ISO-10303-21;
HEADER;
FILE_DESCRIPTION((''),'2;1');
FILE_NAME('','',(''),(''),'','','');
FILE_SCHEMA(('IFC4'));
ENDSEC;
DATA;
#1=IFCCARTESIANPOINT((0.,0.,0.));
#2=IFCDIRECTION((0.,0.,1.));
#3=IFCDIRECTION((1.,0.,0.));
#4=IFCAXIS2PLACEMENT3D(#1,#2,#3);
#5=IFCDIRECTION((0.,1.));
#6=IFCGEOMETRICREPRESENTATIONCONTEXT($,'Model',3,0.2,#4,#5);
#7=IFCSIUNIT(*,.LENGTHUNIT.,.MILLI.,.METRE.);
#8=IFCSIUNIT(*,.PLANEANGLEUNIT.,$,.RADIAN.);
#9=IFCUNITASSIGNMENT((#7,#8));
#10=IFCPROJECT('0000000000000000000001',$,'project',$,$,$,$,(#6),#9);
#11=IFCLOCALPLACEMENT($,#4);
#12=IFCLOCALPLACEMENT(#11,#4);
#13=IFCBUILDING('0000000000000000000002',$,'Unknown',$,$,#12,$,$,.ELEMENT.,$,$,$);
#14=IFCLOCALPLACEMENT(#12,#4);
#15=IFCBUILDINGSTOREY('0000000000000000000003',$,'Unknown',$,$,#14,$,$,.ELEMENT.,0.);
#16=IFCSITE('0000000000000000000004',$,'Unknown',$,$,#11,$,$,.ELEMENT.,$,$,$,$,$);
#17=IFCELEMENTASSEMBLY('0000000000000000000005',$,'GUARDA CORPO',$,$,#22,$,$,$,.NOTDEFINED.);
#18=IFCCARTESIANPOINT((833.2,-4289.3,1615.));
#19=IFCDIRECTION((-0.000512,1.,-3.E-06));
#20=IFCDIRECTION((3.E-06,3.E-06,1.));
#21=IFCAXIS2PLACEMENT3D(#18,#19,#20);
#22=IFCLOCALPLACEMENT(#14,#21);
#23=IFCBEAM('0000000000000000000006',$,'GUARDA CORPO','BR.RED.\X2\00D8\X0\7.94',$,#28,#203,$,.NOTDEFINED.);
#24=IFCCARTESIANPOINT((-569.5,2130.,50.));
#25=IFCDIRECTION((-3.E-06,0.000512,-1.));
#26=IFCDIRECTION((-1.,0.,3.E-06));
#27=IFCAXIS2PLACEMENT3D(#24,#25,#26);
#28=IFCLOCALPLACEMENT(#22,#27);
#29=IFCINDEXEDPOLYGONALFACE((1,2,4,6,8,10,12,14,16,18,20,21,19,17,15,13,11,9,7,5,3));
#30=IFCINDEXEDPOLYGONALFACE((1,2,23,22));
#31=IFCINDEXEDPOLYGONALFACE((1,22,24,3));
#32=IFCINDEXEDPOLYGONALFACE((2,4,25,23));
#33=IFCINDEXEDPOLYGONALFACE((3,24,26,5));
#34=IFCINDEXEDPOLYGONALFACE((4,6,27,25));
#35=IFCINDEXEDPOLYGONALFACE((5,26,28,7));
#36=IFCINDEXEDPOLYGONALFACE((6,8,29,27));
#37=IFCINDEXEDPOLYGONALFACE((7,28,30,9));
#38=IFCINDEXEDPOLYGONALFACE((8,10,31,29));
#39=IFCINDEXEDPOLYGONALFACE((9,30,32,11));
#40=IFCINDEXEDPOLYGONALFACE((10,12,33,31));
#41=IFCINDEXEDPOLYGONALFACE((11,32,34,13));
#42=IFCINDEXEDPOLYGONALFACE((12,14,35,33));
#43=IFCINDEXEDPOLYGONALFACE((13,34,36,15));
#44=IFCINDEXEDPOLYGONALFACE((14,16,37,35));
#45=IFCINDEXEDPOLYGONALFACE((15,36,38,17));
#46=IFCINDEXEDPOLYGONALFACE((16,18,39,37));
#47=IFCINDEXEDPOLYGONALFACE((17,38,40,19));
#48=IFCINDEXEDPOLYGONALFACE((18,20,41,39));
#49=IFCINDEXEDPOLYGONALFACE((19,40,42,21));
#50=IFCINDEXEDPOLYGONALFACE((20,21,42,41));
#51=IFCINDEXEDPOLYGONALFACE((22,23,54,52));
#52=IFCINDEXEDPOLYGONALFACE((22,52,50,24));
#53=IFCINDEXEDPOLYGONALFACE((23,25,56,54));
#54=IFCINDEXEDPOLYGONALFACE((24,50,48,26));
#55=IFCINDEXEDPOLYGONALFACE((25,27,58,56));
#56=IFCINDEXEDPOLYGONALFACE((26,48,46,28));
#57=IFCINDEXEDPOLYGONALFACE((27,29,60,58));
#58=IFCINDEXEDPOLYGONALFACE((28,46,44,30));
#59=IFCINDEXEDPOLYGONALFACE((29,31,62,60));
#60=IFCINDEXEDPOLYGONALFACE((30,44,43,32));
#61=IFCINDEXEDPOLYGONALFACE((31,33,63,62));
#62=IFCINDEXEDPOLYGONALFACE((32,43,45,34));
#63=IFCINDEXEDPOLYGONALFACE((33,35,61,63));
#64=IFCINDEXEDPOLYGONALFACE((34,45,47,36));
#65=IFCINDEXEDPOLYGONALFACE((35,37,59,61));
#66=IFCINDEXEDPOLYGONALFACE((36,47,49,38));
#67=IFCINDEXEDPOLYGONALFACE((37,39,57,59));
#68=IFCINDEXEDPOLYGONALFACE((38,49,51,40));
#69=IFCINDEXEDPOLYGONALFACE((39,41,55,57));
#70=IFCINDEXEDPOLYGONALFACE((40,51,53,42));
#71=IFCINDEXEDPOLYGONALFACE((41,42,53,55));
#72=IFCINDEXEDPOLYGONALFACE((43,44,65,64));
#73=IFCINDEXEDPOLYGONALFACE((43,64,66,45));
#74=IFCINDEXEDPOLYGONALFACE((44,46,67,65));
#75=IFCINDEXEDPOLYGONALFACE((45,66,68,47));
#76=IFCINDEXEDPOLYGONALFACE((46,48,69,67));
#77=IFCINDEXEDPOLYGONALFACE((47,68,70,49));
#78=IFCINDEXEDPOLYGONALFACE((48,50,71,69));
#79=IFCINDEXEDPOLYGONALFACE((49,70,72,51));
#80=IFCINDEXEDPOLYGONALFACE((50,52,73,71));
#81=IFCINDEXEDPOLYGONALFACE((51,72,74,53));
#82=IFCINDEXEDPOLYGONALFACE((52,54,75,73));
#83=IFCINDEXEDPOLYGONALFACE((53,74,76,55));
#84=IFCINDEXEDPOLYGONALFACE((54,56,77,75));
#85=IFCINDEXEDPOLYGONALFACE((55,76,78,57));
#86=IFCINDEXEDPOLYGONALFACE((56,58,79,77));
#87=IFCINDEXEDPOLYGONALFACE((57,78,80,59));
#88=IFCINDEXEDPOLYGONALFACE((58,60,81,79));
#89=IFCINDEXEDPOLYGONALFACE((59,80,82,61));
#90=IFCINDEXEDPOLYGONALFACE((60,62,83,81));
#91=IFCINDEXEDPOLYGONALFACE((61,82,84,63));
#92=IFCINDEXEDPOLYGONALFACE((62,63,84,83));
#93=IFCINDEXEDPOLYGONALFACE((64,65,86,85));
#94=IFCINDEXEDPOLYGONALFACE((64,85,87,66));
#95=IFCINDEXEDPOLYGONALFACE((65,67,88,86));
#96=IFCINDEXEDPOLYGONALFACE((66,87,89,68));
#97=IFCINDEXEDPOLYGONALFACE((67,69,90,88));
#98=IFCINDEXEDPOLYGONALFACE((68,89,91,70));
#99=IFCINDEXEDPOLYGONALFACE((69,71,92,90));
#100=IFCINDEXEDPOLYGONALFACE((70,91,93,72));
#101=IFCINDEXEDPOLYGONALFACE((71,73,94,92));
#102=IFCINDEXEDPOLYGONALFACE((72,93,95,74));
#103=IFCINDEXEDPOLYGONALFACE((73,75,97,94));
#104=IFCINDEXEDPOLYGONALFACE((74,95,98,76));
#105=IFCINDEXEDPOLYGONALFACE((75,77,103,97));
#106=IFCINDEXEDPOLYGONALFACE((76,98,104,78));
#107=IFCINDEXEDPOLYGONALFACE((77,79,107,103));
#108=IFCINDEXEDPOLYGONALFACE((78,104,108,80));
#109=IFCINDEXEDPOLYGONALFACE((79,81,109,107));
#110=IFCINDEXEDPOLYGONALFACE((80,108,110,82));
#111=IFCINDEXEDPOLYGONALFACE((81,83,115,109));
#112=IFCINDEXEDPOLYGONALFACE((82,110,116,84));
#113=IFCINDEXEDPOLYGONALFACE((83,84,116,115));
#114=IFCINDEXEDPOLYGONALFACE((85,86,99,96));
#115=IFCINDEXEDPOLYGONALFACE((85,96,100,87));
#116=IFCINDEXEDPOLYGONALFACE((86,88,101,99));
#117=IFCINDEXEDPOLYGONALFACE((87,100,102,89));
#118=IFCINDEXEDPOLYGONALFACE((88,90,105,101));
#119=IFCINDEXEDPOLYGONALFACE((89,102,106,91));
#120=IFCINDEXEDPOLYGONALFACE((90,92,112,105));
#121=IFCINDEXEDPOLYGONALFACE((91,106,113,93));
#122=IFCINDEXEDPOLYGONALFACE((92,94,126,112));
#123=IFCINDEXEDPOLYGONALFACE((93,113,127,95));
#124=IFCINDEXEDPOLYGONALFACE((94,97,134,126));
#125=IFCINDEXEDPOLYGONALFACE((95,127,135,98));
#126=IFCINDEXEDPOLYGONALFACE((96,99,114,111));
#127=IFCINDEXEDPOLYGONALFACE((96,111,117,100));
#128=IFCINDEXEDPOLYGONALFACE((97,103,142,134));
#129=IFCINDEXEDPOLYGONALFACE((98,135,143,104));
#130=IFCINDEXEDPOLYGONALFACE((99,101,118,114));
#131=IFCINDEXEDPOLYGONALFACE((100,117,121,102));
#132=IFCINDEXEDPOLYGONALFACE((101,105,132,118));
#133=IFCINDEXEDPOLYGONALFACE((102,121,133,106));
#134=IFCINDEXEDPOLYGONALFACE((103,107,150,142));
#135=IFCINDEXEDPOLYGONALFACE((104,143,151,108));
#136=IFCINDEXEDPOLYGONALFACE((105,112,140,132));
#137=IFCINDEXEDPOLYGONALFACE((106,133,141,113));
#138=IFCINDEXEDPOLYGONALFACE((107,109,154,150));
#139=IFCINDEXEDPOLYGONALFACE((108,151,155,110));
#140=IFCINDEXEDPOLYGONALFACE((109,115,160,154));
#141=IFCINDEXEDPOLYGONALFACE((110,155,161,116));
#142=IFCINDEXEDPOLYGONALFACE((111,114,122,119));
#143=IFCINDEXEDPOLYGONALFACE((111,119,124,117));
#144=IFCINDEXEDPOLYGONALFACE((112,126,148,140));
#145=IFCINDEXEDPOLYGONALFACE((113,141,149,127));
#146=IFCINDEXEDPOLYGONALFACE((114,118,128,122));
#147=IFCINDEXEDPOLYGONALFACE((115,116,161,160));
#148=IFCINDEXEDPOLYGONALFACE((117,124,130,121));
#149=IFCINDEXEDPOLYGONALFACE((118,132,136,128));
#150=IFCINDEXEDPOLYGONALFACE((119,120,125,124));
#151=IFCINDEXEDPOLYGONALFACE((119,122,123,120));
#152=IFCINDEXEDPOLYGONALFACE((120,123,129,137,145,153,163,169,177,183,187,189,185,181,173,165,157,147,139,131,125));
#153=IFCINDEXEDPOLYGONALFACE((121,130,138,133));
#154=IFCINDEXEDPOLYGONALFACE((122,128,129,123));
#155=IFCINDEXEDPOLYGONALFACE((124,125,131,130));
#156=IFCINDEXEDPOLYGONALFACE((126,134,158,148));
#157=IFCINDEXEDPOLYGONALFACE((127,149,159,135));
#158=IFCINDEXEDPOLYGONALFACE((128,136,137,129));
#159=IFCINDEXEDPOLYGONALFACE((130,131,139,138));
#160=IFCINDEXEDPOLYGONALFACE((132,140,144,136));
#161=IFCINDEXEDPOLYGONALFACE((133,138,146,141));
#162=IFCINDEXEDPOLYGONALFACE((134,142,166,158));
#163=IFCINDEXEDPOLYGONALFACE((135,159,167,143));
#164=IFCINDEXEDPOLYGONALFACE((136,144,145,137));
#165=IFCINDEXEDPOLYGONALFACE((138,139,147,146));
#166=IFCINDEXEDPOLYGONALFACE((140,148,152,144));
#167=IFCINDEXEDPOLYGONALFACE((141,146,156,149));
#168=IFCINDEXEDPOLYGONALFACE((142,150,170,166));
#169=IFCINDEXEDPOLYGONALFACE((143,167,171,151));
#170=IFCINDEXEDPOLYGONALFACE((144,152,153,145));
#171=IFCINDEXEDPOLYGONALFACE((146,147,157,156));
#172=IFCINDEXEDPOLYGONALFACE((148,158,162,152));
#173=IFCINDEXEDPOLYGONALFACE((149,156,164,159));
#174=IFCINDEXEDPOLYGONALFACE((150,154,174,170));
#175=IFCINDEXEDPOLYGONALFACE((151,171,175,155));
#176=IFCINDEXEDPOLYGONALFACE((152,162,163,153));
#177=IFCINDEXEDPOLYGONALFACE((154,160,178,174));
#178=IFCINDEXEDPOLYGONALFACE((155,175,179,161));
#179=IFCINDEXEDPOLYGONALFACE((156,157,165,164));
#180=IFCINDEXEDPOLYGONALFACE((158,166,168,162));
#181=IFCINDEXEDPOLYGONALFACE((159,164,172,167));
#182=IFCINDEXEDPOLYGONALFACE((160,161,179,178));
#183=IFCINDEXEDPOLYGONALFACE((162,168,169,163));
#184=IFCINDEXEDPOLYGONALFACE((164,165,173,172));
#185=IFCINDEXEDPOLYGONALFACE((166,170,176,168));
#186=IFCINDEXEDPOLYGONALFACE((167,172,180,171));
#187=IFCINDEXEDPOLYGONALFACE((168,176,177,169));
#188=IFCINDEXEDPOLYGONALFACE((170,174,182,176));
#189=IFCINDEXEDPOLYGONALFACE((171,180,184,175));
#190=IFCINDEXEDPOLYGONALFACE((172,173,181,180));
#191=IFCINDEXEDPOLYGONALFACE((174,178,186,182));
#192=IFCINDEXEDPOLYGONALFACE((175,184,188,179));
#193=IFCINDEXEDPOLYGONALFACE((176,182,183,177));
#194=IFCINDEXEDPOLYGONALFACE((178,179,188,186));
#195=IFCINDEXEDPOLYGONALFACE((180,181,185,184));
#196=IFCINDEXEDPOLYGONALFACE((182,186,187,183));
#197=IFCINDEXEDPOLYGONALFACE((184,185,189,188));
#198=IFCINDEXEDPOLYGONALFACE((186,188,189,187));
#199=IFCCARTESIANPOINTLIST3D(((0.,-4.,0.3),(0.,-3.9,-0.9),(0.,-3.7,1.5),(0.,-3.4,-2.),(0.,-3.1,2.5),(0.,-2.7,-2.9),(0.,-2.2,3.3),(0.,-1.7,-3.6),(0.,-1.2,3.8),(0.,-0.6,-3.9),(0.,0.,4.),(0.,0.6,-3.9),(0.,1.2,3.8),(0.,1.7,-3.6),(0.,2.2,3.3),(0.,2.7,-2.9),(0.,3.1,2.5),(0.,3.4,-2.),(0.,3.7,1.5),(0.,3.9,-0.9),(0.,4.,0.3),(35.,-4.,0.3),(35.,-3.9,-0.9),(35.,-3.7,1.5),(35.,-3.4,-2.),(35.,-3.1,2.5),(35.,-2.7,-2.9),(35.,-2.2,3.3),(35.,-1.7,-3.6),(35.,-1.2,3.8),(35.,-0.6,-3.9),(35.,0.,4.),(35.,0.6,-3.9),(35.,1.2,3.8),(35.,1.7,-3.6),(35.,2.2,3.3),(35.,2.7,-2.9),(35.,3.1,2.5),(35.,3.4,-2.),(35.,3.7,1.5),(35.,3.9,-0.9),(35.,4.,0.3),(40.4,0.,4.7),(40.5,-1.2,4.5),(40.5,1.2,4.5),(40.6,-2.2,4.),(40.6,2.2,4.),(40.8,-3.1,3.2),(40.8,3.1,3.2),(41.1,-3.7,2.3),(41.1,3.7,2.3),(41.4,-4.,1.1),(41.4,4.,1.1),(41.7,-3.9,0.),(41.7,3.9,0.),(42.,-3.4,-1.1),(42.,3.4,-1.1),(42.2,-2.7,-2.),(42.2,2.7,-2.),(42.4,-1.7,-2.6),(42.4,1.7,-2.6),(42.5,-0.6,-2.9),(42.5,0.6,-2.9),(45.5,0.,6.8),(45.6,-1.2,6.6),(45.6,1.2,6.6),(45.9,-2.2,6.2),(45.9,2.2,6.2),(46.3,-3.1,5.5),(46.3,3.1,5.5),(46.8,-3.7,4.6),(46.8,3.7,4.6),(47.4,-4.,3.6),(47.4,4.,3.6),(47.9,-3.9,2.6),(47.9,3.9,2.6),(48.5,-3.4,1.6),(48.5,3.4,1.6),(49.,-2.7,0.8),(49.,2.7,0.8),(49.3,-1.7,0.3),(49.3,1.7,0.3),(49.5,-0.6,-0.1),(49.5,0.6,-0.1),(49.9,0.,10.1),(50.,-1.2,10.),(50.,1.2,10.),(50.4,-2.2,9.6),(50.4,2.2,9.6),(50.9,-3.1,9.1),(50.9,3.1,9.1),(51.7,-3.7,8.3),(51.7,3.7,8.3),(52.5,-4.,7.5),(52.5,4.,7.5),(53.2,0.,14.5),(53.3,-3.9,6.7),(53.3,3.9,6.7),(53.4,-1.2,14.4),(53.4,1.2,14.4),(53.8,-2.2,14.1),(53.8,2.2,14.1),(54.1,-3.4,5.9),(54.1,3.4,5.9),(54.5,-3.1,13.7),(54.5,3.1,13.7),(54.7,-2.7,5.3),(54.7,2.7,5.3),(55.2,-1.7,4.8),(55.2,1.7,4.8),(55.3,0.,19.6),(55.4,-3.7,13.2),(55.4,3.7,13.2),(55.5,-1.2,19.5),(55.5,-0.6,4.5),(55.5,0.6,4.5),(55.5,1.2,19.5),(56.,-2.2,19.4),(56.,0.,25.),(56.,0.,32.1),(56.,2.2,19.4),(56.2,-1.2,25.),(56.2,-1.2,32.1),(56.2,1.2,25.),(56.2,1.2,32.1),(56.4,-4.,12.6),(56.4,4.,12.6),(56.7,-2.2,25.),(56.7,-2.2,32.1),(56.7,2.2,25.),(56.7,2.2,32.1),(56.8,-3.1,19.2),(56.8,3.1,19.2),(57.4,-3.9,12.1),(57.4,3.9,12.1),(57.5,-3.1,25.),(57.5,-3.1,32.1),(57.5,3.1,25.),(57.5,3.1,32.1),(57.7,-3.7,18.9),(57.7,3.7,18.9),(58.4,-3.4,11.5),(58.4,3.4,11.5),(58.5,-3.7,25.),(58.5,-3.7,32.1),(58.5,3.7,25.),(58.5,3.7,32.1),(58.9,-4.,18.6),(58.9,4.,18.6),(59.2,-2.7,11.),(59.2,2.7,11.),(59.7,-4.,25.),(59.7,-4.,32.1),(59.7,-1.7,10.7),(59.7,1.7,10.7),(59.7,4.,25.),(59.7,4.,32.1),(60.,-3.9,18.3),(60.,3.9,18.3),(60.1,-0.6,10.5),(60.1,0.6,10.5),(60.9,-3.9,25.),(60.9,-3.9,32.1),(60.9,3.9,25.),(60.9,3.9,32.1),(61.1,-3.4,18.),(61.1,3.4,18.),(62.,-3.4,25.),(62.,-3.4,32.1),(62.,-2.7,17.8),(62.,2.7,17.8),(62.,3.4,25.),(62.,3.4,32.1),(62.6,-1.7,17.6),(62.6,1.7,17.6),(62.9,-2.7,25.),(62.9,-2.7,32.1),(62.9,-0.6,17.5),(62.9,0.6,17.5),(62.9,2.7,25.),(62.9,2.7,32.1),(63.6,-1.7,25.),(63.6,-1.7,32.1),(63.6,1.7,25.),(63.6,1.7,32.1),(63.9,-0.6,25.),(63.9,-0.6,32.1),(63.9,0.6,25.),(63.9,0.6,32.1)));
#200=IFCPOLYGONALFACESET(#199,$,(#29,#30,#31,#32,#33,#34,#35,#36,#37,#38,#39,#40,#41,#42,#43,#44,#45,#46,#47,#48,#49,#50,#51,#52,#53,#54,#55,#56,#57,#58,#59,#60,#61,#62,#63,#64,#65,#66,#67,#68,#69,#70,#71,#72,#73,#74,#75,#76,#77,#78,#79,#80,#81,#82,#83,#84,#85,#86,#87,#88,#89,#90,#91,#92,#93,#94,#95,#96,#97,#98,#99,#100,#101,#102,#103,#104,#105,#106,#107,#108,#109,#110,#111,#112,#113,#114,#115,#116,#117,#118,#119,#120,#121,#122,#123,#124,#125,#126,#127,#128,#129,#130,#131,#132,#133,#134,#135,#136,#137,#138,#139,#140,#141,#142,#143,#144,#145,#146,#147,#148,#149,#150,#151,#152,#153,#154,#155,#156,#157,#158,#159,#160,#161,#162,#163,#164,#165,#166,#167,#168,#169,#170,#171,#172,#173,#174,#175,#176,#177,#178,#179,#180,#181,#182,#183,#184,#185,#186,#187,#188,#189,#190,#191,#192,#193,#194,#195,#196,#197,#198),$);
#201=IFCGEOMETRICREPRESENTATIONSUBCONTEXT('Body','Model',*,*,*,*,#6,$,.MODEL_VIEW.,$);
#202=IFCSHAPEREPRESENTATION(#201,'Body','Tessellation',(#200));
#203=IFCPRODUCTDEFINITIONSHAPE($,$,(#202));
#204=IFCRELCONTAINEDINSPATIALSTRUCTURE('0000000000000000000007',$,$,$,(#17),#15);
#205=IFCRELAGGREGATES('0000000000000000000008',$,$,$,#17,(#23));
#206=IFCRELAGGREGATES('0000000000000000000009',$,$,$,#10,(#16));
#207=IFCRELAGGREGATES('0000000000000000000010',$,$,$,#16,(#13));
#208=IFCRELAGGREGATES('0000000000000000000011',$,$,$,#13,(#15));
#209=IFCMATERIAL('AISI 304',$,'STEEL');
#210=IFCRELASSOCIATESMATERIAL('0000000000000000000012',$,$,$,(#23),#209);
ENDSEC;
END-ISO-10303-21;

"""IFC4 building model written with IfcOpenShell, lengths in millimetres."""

from ifc_helpers import new_model, entity, si_unit, direction, frame, origin_with_axes, place, context, subcontext, project, spatial, material, element, aggregate, save


model = new_model("IFC4")

# Units and contexts
model_context = context("Model", 3, precision=0.2, world=origin_with_axes(), true_north=direction((0.0, 1.0)))
body_context = subcontext(model_context, "Body", "Model", "MODEL_VIEW")
ifc_project = project(units=[si_unit("LENGTHUNIT", "METRE", prefix="MILLI"), si_unit("PLANEANGLEUNIT", "RADIAN")], contexts=[model_context])

# Site, building, storey
site_placement = place(None, origin_with_axes())
site = spatial("IfcSite", under=ifc_project, at=site_placement, Name="Unknown", CompositionType="ELEMENT")
building_placement = place(site_placement, origin_with_axes())
building = spatial("IfcBuilding", under=site, at=building_placement, Name="Unknown", CompositionType="ELEMENT")
storey_placement = place(building_placement, origin_with_axes())
storey = spatial("IfcBuildingStorey", under=building, at=storey_placement, Name="Unknown", CompositionType="ELEMENT", Elevation=0.0)

# Element assembly
assembly_1_placement = place(storey_placement, frame((833.2, -4289.3, 1615.0), z_axis=(-0.000512, 1.0, -0.000003), x_axis=(0.000003, 0.000003, 1.0)))
assembly_1 = element("IfcElementAssembly", 1, at=assembly_1_placement, inside=storey, Name="GUARDA CORPO", PredefinedType="NOTDEFINED")
ifc_material_1 = material(Name="AISI 304", Category="STEEL")

# Beam
beam_1_placement = place(assembly_1_placement, frame((-569.5, 2130.0, 50.0), z_axis=(-0.000003, 0.000512, -1.0), x_axis=(-1.0, 0.0, 0.000003)))
beam_1 = element("IfcBeam", 2, at=beam_1_placement, material=ifc_material_1, Name="GUARDA CORPO", Description="BR.RED.Ø7.94", PredefinedType="NOTDEFINED", context=body_context, shape_type="SolidModel", body=[
    entity("IfcSweptDiskSolid", entity("IfcIndexedPolyCurve", entity("IfcCartesianPointList3D", [[0.0, 0.0, 0.0], [35.0, 0.0, 0.0], [52.7, 0.0, 7.3], [60.0, 0.0, 25.0], [60.0, 0.0, 32.1]]), [entity("IfcLineIndex", [1, 2]), entity("IfcArcIndex", [2, 3, 4]), entity("IfcLineIndex", [4, 5])]), 4.0),
])

aggregate(assembly_1, [beam_1])

save(model, "model.ifc")
